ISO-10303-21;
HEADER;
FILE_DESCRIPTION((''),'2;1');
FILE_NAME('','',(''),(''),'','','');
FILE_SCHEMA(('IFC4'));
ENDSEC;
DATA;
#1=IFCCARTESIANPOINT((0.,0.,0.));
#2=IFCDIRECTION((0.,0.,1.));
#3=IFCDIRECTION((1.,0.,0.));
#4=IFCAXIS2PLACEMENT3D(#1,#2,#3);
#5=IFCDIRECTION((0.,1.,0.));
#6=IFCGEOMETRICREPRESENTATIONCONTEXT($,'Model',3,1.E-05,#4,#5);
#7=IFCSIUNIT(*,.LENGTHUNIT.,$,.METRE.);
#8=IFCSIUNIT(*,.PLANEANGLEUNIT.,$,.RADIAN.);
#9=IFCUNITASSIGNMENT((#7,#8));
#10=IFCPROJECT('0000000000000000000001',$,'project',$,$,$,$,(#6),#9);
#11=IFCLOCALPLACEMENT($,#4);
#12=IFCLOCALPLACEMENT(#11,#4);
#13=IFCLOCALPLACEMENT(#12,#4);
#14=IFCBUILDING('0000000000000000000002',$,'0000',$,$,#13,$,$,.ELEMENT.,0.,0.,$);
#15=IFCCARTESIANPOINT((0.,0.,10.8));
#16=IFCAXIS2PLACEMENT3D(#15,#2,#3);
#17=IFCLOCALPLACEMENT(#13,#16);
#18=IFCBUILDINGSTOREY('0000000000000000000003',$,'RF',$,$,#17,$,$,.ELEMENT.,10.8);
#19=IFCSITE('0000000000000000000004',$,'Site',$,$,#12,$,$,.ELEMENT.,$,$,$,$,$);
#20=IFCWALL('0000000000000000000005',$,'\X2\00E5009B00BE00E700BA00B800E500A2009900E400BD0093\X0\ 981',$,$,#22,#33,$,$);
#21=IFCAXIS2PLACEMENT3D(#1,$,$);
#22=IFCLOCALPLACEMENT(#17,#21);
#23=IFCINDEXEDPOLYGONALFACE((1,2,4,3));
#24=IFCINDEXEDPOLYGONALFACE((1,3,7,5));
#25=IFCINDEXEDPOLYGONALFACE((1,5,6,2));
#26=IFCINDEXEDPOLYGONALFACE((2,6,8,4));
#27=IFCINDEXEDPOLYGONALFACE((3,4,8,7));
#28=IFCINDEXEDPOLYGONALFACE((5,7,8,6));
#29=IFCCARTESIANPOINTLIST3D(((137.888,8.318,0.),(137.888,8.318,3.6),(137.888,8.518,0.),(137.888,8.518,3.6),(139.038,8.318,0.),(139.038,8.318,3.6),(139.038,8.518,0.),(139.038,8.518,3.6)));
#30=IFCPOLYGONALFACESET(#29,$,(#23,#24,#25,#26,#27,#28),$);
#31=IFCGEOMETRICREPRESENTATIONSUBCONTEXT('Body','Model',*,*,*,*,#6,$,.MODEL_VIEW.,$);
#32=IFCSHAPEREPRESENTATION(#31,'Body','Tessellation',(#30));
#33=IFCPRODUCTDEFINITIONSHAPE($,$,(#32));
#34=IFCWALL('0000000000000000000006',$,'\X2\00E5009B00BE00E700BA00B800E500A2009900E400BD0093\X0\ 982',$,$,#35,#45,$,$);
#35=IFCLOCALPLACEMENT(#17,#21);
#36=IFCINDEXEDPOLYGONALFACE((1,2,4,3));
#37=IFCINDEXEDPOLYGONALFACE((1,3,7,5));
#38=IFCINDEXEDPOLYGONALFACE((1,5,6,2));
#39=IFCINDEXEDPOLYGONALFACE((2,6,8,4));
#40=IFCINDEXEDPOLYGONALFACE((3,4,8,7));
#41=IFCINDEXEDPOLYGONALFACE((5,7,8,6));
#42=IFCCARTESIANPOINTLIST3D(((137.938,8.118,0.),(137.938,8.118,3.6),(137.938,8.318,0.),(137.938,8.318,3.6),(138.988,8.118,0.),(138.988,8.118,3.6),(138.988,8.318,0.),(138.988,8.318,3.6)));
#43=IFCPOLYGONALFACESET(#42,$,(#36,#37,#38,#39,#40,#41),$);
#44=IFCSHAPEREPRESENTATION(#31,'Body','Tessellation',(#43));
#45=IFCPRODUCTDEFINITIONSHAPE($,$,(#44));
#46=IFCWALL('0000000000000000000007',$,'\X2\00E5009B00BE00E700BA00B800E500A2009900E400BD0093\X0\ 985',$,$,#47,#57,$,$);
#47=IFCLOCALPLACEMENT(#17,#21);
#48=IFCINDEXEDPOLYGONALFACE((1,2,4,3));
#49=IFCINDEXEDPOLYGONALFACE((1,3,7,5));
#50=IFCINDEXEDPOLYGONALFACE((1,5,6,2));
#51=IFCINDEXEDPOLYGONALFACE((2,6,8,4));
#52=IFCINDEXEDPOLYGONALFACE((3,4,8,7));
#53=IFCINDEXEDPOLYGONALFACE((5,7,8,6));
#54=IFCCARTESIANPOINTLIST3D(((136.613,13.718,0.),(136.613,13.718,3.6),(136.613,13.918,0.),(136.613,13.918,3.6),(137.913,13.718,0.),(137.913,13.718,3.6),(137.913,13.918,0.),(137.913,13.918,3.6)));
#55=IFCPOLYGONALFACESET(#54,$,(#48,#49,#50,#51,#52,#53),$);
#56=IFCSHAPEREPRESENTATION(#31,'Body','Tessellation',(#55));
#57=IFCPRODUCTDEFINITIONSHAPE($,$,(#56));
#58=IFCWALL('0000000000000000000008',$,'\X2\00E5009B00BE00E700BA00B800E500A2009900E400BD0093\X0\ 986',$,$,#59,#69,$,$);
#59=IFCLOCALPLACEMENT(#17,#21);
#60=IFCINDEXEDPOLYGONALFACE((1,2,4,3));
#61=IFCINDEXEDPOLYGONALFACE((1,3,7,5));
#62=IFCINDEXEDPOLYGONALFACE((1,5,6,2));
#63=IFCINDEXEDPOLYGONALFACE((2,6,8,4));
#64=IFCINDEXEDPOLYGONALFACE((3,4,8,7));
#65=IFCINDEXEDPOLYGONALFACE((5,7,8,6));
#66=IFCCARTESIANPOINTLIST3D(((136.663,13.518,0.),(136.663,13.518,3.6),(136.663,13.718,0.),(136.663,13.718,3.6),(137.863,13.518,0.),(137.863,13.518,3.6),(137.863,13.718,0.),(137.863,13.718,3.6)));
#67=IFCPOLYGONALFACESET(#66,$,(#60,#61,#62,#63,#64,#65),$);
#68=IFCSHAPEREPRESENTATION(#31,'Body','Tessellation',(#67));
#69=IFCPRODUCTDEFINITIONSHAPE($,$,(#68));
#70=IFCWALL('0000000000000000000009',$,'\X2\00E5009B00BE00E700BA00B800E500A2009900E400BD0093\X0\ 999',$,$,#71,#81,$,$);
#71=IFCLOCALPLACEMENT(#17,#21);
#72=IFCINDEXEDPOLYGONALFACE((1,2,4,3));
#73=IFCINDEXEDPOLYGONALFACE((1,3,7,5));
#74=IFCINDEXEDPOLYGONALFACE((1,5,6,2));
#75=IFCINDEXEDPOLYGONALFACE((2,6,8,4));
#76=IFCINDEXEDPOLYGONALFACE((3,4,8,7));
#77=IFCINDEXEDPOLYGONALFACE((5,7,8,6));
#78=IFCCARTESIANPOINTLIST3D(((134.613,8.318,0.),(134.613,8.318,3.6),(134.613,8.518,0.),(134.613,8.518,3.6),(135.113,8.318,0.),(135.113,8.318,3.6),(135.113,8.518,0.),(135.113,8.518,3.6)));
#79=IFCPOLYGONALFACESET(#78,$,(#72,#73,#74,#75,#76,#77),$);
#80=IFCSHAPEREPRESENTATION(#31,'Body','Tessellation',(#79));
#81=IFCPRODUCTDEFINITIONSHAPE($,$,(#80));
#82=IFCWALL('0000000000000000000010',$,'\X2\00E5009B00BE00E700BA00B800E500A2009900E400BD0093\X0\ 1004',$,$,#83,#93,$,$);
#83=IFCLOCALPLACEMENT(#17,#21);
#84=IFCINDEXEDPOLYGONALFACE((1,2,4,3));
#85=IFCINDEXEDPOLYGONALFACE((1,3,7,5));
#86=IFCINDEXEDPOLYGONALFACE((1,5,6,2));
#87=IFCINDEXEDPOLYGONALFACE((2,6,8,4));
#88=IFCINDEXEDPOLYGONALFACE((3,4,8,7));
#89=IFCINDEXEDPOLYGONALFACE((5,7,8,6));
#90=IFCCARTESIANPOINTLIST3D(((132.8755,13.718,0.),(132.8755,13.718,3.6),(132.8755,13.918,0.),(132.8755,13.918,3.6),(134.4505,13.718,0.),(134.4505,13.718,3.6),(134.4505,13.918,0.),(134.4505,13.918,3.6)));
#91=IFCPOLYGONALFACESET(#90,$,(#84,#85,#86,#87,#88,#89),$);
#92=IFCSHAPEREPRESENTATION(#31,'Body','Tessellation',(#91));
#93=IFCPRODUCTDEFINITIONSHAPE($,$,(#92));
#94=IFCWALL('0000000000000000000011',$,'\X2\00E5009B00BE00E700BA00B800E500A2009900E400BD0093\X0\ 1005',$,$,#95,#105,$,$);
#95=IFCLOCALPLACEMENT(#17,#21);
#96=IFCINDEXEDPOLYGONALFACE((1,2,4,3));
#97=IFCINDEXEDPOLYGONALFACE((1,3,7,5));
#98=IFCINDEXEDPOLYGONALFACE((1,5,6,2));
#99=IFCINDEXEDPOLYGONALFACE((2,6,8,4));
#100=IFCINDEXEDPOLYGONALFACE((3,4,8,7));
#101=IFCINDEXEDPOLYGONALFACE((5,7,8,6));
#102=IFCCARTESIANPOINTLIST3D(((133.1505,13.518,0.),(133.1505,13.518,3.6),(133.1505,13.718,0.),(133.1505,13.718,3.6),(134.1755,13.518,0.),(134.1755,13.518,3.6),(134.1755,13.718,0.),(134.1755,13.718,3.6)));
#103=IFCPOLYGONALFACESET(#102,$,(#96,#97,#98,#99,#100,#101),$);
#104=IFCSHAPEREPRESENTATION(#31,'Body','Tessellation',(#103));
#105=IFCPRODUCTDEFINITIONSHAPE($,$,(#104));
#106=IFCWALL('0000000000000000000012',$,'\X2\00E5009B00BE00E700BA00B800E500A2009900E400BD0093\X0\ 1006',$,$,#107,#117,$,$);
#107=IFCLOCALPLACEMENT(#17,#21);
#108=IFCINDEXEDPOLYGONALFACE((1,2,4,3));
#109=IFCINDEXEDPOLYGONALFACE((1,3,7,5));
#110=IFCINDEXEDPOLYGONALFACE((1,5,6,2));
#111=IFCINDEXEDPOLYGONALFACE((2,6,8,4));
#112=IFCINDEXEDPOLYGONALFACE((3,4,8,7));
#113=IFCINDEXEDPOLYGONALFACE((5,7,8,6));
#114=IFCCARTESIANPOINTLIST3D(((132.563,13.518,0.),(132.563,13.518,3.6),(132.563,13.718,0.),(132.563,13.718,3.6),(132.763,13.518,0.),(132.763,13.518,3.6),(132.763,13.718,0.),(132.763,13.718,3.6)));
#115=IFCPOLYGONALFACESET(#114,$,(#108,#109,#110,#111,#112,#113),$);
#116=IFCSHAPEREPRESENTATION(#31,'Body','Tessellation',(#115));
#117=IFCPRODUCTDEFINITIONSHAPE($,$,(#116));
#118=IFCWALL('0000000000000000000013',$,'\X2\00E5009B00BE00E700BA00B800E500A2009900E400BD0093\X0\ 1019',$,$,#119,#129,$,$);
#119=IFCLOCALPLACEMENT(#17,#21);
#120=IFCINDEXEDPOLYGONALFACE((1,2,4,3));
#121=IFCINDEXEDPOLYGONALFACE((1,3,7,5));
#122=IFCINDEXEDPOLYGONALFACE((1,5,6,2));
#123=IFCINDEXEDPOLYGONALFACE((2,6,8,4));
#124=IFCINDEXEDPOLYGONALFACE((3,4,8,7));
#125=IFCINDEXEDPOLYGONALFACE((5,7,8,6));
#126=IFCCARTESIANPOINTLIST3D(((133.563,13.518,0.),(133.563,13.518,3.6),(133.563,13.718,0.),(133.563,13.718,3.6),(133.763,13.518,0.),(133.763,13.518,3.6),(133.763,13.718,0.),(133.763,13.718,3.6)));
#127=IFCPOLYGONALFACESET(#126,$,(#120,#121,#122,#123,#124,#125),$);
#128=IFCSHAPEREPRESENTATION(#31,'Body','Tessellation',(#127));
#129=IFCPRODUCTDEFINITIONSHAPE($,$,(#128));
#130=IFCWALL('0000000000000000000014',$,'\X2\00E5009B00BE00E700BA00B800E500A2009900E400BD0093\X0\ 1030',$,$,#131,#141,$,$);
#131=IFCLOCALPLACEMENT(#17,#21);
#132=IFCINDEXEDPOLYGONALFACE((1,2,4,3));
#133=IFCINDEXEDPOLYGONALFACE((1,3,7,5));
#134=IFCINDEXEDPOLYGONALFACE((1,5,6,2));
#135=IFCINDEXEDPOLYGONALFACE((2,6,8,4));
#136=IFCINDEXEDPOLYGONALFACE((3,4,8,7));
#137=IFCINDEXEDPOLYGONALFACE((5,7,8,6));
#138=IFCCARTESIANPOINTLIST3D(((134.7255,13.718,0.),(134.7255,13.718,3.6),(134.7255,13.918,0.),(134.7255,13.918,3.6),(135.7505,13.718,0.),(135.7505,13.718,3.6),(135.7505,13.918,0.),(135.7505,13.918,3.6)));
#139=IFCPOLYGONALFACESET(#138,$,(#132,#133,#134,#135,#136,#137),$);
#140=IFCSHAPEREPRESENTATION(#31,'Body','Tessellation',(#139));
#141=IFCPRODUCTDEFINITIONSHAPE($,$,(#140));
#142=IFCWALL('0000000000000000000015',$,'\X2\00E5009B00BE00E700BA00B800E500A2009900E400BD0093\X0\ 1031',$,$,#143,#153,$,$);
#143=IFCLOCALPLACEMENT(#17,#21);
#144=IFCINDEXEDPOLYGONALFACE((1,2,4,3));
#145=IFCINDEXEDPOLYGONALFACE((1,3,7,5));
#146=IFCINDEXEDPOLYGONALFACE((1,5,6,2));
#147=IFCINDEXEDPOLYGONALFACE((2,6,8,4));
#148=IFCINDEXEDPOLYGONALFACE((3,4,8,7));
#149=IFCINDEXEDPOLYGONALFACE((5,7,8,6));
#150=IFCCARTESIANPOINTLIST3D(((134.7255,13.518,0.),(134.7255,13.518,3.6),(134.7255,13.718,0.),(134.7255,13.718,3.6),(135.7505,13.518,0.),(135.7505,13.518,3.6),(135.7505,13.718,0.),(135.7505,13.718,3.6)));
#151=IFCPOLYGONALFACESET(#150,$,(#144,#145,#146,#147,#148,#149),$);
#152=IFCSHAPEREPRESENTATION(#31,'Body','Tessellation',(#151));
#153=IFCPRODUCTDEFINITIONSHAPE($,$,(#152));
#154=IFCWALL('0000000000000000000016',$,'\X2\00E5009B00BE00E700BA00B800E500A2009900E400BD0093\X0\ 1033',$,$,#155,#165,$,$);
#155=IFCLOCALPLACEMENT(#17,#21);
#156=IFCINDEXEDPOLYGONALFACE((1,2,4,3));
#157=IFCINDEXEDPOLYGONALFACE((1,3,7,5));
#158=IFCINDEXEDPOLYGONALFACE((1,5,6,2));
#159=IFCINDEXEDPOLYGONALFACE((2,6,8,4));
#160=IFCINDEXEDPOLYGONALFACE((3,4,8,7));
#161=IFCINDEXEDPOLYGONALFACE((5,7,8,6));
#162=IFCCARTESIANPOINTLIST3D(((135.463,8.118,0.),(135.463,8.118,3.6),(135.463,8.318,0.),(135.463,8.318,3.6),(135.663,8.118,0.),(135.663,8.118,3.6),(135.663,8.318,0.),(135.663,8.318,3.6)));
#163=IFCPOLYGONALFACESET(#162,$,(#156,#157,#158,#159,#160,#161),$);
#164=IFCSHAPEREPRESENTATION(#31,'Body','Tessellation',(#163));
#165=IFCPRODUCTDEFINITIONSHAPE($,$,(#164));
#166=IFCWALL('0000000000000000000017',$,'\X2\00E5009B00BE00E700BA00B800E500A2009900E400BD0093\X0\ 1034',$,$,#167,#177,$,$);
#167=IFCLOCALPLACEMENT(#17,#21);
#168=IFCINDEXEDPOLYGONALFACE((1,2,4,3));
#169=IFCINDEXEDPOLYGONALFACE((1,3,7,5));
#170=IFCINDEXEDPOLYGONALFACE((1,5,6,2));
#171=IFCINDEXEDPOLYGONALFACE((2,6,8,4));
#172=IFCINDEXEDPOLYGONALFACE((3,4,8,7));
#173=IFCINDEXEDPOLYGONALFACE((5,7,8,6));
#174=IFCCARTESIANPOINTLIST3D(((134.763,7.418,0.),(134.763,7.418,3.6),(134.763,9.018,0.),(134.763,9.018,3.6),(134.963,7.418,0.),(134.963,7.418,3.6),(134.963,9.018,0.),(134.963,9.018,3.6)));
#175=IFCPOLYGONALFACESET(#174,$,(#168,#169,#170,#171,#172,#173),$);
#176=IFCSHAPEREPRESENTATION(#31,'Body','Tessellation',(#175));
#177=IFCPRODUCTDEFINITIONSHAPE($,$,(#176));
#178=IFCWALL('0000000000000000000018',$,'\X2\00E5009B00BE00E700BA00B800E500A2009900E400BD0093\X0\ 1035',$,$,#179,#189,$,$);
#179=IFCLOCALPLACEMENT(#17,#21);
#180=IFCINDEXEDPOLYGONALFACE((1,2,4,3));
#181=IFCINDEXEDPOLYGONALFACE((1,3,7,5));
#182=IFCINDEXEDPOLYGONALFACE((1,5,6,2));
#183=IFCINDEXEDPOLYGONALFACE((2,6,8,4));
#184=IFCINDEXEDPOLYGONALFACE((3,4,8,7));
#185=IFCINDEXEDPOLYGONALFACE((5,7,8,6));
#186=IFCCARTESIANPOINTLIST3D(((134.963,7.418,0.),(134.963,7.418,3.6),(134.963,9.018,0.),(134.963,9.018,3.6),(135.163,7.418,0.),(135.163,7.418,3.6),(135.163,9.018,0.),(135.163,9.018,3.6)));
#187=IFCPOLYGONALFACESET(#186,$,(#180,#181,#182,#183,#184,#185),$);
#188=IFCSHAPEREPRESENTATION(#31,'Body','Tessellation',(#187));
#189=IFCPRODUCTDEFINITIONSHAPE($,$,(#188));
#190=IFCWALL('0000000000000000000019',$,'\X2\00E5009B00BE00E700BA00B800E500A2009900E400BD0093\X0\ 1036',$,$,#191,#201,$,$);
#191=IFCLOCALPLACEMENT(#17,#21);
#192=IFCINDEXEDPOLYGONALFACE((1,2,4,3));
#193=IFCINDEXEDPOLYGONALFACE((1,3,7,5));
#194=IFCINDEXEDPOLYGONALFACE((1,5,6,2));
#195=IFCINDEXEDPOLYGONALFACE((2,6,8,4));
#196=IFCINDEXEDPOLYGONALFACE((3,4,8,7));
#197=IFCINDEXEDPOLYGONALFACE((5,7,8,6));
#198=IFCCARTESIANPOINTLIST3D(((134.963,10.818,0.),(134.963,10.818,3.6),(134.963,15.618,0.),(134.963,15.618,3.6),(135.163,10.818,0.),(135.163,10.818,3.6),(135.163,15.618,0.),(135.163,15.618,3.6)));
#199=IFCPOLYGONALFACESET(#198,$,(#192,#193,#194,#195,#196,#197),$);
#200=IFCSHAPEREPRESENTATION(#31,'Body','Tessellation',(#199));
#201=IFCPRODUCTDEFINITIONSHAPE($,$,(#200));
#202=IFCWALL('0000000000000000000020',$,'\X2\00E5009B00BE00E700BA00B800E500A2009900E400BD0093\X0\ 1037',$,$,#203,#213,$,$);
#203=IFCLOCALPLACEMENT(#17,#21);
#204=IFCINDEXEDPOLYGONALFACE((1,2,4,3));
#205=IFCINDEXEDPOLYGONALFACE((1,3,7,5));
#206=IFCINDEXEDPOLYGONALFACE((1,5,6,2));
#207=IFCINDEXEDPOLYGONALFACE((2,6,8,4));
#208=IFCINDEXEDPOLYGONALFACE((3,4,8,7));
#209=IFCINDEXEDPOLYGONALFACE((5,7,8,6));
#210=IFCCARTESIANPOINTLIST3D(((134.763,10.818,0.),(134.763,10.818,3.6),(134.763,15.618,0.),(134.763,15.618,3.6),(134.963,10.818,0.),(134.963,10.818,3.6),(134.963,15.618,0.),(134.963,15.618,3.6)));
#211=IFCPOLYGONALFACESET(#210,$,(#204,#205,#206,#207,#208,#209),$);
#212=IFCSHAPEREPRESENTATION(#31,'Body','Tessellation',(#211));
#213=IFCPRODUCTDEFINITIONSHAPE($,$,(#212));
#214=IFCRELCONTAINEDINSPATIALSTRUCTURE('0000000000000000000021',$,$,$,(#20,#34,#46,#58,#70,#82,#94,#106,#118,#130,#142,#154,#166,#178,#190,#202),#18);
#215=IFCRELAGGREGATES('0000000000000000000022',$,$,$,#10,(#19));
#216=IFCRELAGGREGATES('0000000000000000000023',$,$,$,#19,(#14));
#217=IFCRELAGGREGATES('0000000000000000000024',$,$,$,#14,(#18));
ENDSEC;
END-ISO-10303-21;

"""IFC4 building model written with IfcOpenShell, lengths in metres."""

from ifc_helpers import new_model, si_unit, direction, frame, frame_2d, origin_with_axes, place, context, subcontext, project, spatial, rectangle, extrude, element, save


model = new_model("IFC4")

# Units and contexts
model_context = context("Model", 3, precision=1e-05, world=origin_with_axes(), true_north=direction((0.0, 1.0, 0.0)))
body_context = subcontext(model_context, "Body", "Model", "MODEL_VIEW")
ifc_project = project(units=[si_unit("LENGTHUNIT", "METRE"), si_unit("PLANEANGLEUNIT", "RADIAN")], contexts=[model_context])

# Site, building, storey
placement = place(None, origin_with_axes())
site_placement = place(placement, origin_with_axes())
site = spatial("IfcSite", under=ifc_project, at=site_placement, Name="Site", CompositionType="ELEMENT")
building_placement = place(site_placement, origin_with_axes())
building = spatial("IfcBuilding", under=site, at=building_placement, Name="0000", CompositionType="ELEMENT", ElevationOfRefHeight=0.0, ElevationOfTerrain=0.0)
storey_placement = place(building_placement, frame((0.0, 0.0, 10.8), z_axis=(0.0, 0.0, 1.0), x_axis=(1.0, 0.0, 0.0)))
storey = spatial("IfcBuildingStorey", under=building, at=storey_placement, Name="RF", CompositionType="ELEMENT", Elevation=10.8)

# Walls
wall_1_placement = place(storey_placement, frame((138.463, 8.418, 0.0), z_axis=(0.0, 0.0, 1.0), x_axis=(-1.0, 0.0, 0.0)))
element("IfcWall", 1, at=wall_1_placement, inside=storey, Name="å\u009b¾çº¸å¢\u0099ä½\u0093 981", context=body_context, shape_type="SweptSolid", body=[
    extrude(rectangle(XDim=1.15, YDim=0.2, at=frame_2d((0.0, 0.0), x_axis=(1.0, 0.0, 0.0))), frame((0.0, 0.0, 0.0), z_axis=(0.0, 0.0, 1.0)), (0.0, 0.0, 1.0), 3.6),
])
wall_2_placement = place(storey_placement, frame((138.463, 8.218, 0.0), z_axis=(0.0, 0.0, 1.0), x_axis=(-1.0, 0.0, 0.0)))
element("IfcWall", 2, at=wall_2_placement, inside=storey, Name="å\u009b¾çº¸å¢\u0099ä½\u0093 982", context=body_context, shape_type="SweptSolid", body=[
    extrude(rectangle(XDim=1.05, YDim=0.2, at=frame_2d((0.0, 0.0), x_axis=(1.0, 0.0, 0.0))), frame((0.0, 0.0, 0.0), z_axis=(0.0, 0.0, 1.0)), (0.0, 0.0, 1.0), 3.6),
])
wall_3_placement = place(storey_placement, frame((137.263, 13.818, 0.0), z_axis=(0.0, 0.0, 1.0), x_axis=(1.0, 0.0, 0.0)))
element("IfcWall", 3, at=wall_3_placement, inside=storey, Name="å\u009b¾çº¸å¢\u0099ä½\u0093 985", context=body_context, shape_type="SweptSolid", body=[
    extrude(rectangle(XDim=1.3, YDim=0.2, at=frame_2d((0.0, 0.0), x_axis=(1.0, 0.0, 0.0))), frame((0.0, 0.0, 0.0), z_axis=(0.0, 0.0, 1.0)), (0.0, 0.0, 1.0), 3.6),
])
wall_4_placement = place(storey_placement, frame((137.263, 13.618, 0.0), z_axis=(0.0, 0.0, 1.0), x_axis=(1.0, 0.0, 0.0)))
element("IfcWall", 4, at=wall_4_placement, inside=storey, Name="å\u009b¾çº¸å¢\u0099ä½\u0093 986", context=body_context, shape_type="SweptSolid", body=[
    extrude(rectangle(XDim=1.2, YDim=0.2, at=frame_2d((0.0, 0.0), x_axis=(1.0, 0.0, 0.0))), frame((0.0, 0.0, 0.0), z_axis=(0.0, 0.0, 1.0)), (0.0, 0.0, 1.0), 3.6),
])
wall_5_placement = place(storey_placement, frame((134.863, 8.418, 0.0), z_axis=(0.0, 0.0, 1.0), x_axis=(-1.0, 0.0, 0.0)))
element("IfcWall", 5, at=wall_5_placement, inside=storey, Name="å\u009b¾çº¸å¢\u0099ä½\u0093 999", context=body_context, shape_type="SweptSolid", body=[
    extrude(rectangle(XDim=0.5, YDim=0.2, at=frame_2d((0.0, 0.0), x_axis=(1.0, 0.0, 0.0))), frame((0.0, 0.0, 0.0), z_axis=(0.0, 0.0, 1.0)), (0.0, 0.0, 1.0), 3.6),
])
wall_6_placement = place(storey_placement, frame((133.663, 13.818, 0.0), z_axis=(0.0, 0.0, 1.0), x_axis=(1.0, 0.0, 0.0)))
element("IfcWall", 6, at=wall_6_placement, inside=storey, Name="å\u009b¾çº¸å¢\u0099ä½\u0093 1004", context=body_context, shape_type="SweptSolid", body=[
    extrude(rectangle(XDim=1.575, YDim=0.2, at=frame_2d((0.0, 0.0), x_axis=(1.0, 0.0, 0.0))), frame((0.0, 0.0, 0.0), z_axis=(0.0, 0.0, 1.0)), (0.0, 0.0, 1.0), 3.6),
])
wall_7_placement = place(storey_placement, frame((133.663, 13.618, 0.0), z_axis=(0.0, 0.0, 1.0), x_axis=(1.0, 0.0, 0.0)))
element("IfcWall", 7, at=wall_7_placement, inside=storey, Name="å\u009b¾çº¸å¢\u0099ä½\u0093 1005", context=body_context, shape_type="SweptSolid", body=[
    extrude(rectangle(XDim=1.025, YDim=0.2, at=frame_2d((0.0, 0.0), x_axis=(1.0, 0.0, 0.0))), frame((0.0, 0.0, 0.0), z_axis=(0.0, 0.0, 1.0)), (0.0, 0.0, 1.0), 3.6),
])
for number, where, z_axis, x_axis, name in (
    (8, (132.663, 13.618, 0.0), (0.0, 0.0, 1.0), (0.0, 1.0, 0.0), "å\u009b¾çº¸å¢\u0099ä½\u0093 1006"),
    (9, (133.663, 13.618, 0.0), (0.0, 0.0, 1.0), (0.0, 1.0, 0.0), "å\u009b¾çº¸å¢\u0099ä½\u0093 1019"),
):
    element("IfcWall", number, at=place(storey_placement, frame(where, z_axis=z_axis, x_axis=x_axis)), inside=storey, Name=name, context=body_context, shape_type="SweptSolid", body=[
        extrude(rectangle(XDim=0.2, YDim=0.2, at=frame_2d((0.0, 0.0), x_axis=(1.0, 0.0, 0.0))), frame((0.0, 0.0, 0.0), z_axis=(0.0, 0.0, 1.0)), (0.0, 0.0, 1.0), 3.6),
    ])
for number, where, z_axis, x_axis, name in (
    (10, (135.238, 13.818, 0.0), (0.0, 0.0, 1.0), (1.0, 0.0, 0.0), "å\u009b¾çº¸å¢\u0099ä½\u0093 1030"),
    (11, (135.238, 13.618, 0.0), (0.0, 0.0, 1.0), (1.0, 0.0, 0.0), "å\u009b¾çº¸å¢\u0099ä½\u0093 1031"),
):
    element("IfcWall", number, at=place(storey_placement, frame(where, z_axis=z_axis, x_axis=x_axis)), inside=storey, Name=name, context=body_context, shape_type="SweptSolid", body=[
        extrude(rectangle(XDim=1.025, YDim=0.2, at=frame_2d((0.0, 0.0), x_axis=(1.0, 0.0, 0.0))), frame((0.0, 0.0, 0.0), z_axis=(0.0, 0.0, 1.0)), (0.0, 0.0, 1.0), 3.6),
    ])
wall_8_placement = place(storey_placement, frame((135.563, 8.218, 0.0), z_axis=(0.0, 0.0, 1.0), x_axis=(0.0, 1.0, 0.0)))
element("IfcWall", 12, at=wall_8_placement, inside=storey, Name="å\u009b¾çº¸å¢\u0099ä½\u0093 1033", context=body_context, shape_type="SweptSolid", body=[
    extrude(rectangle(XDim=0.2, YDim=0.2, at=frame_2d((0.0, 0.0), x_axis=(1.0, 0.0, 0.0))), frame((0.0, 0.0, 0.0), z_axis=(0.0, 0.0, 1.0)), (0.0, 0.0, 1.0), 3.6),
])
for number, where, z_axis, x_axis, name in (
    (13, (134.863, 8.218, 0.0), (0.0, 0.0, 1.0), (0.0, -1.0, 0.0), "å\u009b¾çº¸å¢\u0099ä½\u0093 1034"),
    (14, (135.063, 8.218, 0.0), (0.0, 0.0, 1.0), (0.0, -1.0, 0.0), "å\u009b¾çº¸å¢\u0099ä½\u0093 1035"),
):
    element("IfcWall", number, at=place(storey_placement, frame(where, z_axis=z_axis, x_axis=x_axis)), inside=storey, Name=name, context=body_context, shape_type="SweptSolid", body=[
        extrude(rectangle(XDim=1.6, YDim=0.2, at=frame_2d((0.0, 0.0), x_axis=(1.0, 0.0, 0.0))), frame((0.0, 0.0, 0.0), z_axis=(0.0, 0.0, 1.0)), (0.0, 0.0, 1.0), 3.6),
    ])
for number, where, z_axis, x_axis, name in (
    (15, (135.063, 13.218, 0.0), (0.0, 0.0, 1.0), (0.0, -1.0, 0.0), "å\u009b¾çº¸å¢\u0099ä½\u0093 1036"),
    (16, (134.863, 13.218, 0.0), (0.0, 0.0, 1.0), (0.0, -1.0, 0.0), "å\u009b¾çº¸å¢\u0099ä½\u0093 1037"),
):
    element("IfcWall", number, at=place(storey_placement, frame(where, z_axis=z_axis, x_axis=x_axis)), inside=storey, Name=name, context=body_context, shape_type="SweptSolid", body=[
        extrude(rectangle(XDim=4.8, YDim=0.2, at=frame_2d((0.0, 0.0), x_axis=(1.0, 0.0, 0.0))), frame((0.0, 0.0, 0.0), z_axis=(0.0, 0.0, 1.0)), (0.0, 0.0, 1.0), 3.6),
    ])

save(model, "model.ifc")
